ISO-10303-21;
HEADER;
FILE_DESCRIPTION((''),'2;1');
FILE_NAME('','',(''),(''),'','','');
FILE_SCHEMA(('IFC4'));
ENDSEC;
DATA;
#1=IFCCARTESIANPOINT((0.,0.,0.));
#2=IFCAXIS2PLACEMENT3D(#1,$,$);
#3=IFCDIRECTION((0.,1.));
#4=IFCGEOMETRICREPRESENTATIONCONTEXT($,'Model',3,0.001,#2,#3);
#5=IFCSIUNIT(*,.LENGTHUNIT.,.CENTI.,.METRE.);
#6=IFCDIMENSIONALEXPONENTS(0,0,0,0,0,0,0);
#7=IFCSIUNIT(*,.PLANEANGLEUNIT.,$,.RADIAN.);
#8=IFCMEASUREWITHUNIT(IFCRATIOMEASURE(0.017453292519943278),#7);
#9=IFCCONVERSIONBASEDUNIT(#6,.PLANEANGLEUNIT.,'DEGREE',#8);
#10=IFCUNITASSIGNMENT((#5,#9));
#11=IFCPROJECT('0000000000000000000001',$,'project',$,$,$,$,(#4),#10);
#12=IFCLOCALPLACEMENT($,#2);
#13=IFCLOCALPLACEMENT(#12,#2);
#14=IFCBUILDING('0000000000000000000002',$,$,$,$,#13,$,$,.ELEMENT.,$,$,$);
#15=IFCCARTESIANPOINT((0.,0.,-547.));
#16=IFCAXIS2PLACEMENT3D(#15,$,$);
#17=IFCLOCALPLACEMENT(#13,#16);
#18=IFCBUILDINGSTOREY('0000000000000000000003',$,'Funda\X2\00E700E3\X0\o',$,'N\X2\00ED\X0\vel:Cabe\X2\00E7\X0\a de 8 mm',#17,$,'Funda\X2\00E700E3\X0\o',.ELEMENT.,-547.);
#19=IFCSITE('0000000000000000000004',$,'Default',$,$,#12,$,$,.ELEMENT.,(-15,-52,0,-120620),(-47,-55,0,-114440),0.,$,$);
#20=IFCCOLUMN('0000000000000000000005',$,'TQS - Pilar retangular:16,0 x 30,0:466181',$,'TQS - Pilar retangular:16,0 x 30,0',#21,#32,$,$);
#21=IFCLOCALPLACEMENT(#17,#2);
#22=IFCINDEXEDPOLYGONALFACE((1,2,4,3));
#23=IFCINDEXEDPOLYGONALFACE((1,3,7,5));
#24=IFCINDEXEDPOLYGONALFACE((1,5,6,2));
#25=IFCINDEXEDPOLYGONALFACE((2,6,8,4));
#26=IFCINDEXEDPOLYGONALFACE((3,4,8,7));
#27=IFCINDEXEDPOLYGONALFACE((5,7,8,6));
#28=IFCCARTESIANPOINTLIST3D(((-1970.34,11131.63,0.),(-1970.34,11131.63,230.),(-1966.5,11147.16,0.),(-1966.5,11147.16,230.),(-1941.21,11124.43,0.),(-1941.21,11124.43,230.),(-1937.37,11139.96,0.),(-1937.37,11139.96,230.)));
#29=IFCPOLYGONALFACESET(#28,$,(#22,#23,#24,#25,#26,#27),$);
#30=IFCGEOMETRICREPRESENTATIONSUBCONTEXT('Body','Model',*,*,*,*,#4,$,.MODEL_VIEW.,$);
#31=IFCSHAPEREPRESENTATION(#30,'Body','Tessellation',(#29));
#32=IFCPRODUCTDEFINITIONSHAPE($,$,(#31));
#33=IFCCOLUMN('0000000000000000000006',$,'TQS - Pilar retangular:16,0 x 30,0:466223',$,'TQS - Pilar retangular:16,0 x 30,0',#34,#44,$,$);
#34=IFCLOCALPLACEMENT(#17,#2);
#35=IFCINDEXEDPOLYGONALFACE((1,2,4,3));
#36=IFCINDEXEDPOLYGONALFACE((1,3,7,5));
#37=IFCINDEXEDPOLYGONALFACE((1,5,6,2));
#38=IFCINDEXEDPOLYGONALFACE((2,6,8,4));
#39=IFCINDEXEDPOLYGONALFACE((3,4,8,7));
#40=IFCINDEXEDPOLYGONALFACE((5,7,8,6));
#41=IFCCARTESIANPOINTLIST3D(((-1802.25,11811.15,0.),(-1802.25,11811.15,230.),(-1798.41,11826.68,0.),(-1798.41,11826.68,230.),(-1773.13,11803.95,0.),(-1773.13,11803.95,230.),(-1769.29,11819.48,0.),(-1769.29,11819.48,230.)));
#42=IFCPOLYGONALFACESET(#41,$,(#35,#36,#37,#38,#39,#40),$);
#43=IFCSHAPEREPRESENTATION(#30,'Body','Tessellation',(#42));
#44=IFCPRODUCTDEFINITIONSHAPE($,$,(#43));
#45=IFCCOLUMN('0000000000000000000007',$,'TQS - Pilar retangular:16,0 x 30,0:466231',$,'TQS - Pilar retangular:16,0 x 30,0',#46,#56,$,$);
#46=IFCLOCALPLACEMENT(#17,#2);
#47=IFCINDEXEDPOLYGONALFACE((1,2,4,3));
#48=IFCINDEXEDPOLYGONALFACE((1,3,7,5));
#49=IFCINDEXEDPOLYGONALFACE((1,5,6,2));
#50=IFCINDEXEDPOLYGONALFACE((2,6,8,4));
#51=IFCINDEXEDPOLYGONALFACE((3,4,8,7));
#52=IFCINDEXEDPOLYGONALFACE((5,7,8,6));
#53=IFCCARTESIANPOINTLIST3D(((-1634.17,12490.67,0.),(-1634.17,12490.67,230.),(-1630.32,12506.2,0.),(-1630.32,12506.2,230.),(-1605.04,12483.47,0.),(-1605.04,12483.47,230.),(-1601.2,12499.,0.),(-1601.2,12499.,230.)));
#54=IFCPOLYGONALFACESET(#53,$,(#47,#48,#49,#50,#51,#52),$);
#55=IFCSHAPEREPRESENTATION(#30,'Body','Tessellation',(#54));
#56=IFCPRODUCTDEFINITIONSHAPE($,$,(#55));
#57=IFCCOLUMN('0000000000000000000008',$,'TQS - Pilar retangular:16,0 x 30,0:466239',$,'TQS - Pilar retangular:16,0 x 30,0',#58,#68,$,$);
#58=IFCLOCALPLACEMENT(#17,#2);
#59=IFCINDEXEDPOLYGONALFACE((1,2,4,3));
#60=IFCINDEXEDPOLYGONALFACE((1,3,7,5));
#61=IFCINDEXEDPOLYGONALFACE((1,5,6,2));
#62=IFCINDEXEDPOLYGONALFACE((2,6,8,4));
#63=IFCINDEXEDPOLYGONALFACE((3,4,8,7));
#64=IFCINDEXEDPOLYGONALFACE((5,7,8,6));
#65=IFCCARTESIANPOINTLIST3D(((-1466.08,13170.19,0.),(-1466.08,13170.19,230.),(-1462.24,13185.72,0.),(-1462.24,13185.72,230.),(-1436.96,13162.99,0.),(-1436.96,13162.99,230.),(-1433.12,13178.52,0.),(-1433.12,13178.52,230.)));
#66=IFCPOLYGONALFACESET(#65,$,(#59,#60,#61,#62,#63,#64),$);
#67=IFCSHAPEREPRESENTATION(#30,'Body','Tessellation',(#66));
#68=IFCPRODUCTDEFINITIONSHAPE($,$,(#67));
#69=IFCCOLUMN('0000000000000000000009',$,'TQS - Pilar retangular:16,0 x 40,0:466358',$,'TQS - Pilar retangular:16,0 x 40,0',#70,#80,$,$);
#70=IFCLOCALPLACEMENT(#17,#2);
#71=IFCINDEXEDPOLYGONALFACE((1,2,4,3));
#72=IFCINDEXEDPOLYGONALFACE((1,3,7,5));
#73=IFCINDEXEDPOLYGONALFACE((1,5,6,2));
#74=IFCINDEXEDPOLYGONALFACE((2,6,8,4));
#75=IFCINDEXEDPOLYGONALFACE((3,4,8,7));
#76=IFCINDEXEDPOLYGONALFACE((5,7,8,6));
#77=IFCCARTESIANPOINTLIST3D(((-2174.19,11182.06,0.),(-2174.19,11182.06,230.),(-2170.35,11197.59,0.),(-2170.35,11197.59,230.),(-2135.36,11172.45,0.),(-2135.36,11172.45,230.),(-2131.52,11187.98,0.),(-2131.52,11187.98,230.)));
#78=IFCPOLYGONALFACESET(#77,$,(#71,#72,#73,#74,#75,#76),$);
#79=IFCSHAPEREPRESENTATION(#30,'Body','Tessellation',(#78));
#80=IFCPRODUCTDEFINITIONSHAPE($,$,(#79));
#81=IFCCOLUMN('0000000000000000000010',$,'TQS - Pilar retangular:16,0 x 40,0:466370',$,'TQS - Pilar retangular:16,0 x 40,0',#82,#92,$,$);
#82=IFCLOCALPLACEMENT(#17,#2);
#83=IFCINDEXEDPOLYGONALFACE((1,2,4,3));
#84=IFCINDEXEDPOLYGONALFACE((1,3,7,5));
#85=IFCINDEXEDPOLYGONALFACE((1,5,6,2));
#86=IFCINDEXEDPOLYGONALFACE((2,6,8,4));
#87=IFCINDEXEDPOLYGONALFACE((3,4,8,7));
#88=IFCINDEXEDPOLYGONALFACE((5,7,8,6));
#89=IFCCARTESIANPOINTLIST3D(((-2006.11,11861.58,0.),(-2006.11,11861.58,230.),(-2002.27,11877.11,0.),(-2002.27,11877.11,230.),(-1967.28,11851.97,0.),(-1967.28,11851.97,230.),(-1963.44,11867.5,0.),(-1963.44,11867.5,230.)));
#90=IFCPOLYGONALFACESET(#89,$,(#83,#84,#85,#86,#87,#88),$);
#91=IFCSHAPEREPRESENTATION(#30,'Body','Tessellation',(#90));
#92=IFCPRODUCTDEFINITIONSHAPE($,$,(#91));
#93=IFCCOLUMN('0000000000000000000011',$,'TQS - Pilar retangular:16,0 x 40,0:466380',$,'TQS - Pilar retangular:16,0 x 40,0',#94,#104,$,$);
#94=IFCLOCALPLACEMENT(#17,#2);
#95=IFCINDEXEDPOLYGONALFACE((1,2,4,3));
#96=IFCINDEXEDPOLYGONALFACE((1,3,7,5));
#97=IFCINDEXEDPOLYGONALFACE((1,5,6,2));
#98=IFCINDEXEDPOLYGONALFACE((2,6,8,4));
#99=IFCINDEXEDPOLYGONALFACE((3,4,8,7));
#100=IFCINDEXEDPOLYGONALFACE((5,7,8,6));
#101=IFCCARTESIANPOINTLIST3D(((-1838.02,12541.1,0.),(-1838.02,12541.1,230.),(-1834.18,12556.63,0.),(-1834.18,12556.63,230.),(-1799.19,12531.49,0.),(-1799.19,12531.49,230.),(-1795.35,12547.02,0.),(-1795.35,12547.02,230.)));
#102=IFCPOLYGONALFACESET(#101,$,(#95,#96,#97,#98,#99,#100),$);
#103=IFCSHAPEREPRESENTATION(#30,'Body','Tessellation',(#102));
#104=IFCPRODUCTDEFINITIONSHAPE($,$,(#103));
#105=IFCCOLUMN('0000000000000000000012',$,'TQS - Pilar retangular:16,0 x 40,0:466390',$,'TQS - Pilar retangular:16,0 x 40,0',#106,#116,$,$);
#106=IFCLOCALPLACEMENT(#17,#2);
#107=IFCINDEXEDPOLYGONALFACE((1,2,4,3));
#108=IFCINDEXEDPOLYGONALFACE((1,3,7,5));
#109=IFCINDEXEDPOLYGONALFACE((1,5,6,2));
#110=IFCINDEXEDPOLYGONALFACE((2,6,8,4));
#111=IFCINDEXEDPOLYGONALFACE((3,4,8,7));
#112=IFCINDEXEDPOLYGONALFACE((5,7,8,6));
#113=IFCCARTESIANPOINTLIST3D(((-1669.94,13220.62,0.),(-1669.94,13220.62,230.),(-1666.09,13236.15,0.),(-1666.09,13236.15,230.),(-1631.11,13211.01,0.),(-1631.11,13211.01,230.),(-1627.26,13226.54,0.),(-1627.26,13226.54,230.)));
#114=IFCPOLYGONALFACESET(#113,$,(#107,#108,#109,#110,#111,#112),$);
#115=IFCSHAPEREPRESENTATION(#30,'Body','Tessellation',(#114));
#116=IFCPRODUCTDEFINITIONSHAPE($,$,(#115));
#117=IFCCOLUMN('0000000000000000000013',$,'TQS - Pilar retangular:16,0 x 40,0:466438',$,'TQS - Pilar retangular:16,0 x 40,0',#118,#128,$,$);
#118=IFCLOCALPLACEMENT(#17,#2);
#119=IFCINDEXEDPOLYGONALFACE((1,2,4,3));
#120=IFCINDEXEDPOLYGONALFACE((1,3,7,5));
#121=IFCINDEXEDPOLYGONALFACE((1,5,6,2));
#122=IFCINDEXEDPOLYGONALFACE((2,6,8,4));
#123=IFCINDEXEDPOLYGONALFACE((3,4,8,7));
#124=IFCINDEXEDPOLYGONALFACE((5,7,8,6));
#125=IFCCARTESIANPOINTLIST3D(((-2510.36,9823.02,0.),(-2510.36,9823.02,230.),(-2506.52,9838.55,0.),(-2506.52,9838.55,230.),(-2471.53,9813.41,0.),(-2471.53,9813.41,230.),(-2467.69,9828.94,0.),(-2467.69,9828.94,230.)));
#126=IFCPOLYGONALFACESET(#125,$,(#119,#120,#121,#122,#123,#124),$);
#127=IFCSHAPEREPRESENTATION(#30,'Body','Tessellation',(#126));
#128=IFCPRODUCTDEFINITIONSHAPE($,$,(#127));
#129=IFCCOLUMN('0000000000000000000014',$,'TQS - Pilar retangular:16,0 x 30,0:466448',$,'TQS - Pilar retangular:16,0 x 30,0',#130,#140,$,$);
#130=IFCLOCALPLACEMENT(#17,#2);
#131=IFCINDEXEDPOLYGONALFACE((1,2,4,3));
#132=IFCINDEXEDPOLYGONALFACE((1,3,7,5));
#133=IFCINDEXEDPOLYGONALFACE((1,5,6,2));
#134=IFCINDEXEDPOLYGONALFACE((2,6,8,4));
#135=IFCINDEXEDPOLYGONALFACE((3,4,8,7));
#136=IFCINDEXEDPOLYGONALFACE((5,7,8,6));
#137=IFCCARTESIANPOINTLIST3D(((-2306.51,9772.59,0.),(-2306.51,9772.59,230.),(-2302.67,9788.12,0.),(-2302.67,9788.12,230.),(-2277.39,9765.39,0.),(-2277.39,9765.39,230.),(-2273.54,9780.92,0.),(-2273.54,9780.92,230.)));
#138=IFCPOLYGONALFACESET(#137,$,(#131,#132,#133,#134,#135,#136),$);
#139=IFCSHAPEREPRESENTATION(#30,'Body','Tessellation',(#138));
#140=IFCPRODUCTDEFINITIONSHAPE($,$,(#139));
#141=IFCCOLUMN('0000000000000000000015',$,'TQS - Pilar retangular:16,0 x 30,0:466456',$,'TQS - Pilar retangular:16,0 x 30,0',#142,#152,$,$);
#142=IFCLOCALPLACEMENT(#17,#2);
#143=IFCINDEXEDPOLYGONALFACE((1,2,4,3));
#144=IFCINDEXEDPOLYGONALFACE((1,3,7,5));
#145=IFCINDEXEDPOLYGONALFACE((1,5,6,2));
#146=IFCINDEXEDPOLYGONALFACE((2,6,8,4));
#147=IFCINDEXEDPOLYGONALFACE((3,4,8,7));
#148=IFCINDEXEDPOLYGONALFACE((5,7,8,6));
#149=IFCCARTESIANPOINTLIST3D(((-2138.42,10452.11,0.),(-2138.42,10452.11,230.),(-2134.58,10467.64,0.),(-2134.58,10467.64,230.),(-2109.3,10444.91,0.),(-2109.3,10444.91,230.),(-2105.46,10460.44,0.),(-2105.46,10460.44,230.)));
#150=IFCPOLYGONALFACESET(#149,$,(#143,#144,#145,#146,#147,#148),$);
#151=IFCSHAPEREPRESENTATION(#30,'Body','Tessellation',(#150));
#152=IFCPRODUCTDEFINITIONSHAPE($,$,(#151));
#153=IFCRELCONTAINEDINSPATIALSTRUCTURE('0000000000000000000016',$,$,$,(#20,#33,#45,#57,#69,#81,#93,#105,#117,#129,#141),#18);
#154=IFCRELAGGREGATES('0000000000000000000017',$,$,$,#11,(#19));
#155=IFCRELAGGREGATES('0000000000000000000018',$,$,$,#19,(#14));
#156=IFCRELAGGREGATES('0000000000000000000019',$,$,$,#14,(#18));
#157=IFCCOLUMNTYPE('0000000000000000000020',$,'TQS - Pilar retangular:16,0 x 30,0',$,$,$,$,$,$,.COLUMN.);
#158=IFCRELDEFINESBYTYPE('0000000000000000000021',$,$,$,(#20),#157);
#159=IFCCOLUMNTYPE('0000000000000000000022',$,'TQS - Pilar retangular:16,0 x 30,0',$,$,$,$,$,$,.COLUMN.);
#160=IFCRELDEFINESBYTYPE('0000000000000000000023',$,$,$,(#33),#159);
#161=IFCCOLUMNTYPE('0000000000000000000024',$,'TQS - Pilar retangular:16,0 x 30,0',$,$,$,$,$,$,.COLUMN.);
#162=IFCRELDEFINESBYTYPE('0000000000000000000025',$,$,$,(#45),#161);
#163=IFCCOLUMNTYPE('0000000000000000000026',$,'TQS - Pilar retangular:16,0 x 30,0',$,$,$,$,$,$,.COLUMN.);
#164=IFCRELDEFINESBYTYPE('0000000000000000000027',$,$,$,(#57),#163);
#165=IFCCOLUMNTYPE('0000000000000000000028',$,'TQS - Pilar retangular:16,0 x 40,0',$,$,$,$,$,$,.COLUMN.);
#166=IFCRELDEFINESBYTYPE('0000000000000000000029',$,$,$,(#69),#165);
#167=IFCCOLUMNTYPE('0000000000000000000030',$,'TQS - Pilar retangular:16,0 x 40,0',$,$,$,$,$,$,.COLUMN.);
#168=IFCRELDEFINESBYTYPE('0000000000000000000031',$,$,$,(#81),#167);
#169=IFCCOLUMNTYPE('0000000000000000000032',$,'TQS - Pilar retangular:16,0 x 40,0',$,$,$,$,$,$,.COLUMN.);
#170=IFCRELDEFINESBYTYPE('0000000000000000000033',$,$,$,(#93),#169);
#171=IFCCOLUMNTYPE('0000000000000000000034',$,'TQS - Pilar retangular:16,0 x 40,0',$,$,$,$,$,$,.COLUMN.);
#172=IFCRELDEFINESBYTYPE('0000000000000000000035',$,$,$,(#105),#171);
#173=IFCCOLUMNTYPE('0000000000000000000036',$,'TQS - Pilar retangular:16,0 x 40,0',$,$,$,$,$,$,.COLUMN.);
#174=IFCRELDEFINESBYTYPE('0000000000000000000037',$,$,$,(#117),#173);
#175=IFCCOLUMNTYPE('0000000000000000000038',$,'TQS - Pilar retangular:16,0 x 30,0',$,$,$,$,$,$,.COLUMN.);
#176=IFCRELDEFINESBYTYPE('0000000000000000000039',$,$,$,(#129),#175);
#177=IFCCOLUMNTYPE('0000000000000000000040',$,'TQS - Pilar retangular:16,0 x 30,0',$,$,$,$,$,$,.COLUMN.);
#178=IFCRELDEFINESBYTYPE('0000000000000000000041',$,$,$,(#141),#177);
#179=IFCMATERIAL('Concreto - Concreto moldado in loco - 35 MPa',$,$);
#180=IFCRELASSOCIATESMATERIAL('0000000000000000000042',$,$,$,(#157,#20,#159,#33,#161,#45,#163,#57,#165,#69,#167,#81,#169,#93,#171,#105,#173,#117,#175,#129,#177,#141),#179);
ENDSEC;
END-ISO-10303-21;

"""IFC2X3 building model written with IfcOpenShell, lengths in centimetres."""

from ifc_helpers import new_model, entity, si_unit, converted_unit, direction, frame, frame_2d, origin, origin_2d_with_axis, place, context, subcontext, project, spatial, rectangle, extrude, source, transform, mapped, material, type_object, type_shapes, element, save


model = new_model("IFC2X3")

# Units and contexts
model_context = context("Model", 3, precision=0.001, world=origin(), true_north=direction((0.0, 1.0)))
body_context = subcontext(model_context, "Body", "Model", "MODEL_VIEW")
ifc_project = project(units=[si_unit("LENGTHUNIT", "METRE", prefix="CENTI"), converted_unit("PLANEANGLEUNIT", "DEGREE", entity("IfcRatioMeasure", 0.017453292519943278), si_unit("PLANEANGLEUNIT", "RADIAN"), dimensions=[0, 0, 0, 0, 0, 0, 0])], contexts=[model_context])

# Site, building, storey
site_placement = place(None, origin())
site = spatial("IfcSite", under=ifc_project, at=site_placement, Name="Default", CompositionType="ELEMENT", RefLatitude=(-15, -52, 0, -120620), RefLongitude=(-47, -55, 0, -114440), RefElevation=0.0)
building_placement = place(site_placement, origin())
building = spatial("IfcBuilding", under=site, at=building_placement, CompositionType="ELEMENT")
storey_placement = place(building_placement, frame((0.0, 0.0, -547.0)))
storey = spatial("IfcBuildingStorey", under=building, at=storey_placement, Name="Fundação", ObjectType="Nível:Cabeça de 8 mm", LongName="Fundação", CompositionType="ELEMENT", Elevation=-547.0)

# Columns
ifc_material_1 = material(Name="Concreto - Concreto moldado in loco - 35 MPa")
column_type_1 = type_object("IfcColumnType", Name="TQS - Pilar retangular:16,0 x 30,0", PredefinedType="COLUMN", material=ifc_material_1)
shared_shape_1 = source(origin(), body_context, "Body", "SweptSolid", [
    extrude(rectangle(XDim=30.0, YDim=16.0, at=frame_2d((0.0, 0.0), x_axis=(1.0, 0.0))), frame((-1953.86, 11135.79, -547.0), z_axis=(0.0, 0.0, 1.0), x_axis=(-0.970743, 0.240122, 0.0)), (0.0, 0.0, 1.0), 230.0),
])
type_shapes(column_type_1, [shared_shape_1])
column_1_placement = place(storey_placement, frame((0.0, 0.0, 547.0)))
element("IfcColumn", 1, at=column_1_placement, inside=storey, type_object=column_type_1, material=ifc_material_1, Name="TQS - Pilar retangular:16,0 x 30,0:466181", ObjectType="TQS - Pilar retangular:16,0 x 30,0", context=body_context, shape_type="MappedRepresentation", body=[
    mapped(shared_shape_1, transform((0.0, 0.0, 0.0), scale=1.0)),
])
column_type_2 = type_object("IfcColumnType", Name="TQS - Pilar retangular:16,0 x 30,0", PredefinedType="COLUMN", material=ifc_material_1)
shared_shape_2 = source(origin(), body_context, "Body", "SweptSolid", [
    extrude(rectangle(XDim=30.0, YDim=16.0, at=origin_2d_with_axis()), frame((-1785.77, 11815.31, -547.0), z_axis=(0.0, 0.0, 1.0), x_axis=(-0.970743, 0.240122, 0.0)), (0.0, 0.0, 1.0), 230.0),
])
type_shapes(column_type_2, [shared_shape_2])
column_2_placement = place(storey_placement, frame((0.0, 0.0, 547.0)))
element("IfcColumn", 2, at=column_2_placement, inside=storey, type_object=column_type_2, material=ifc_material_1, Name="TQS - Pilar retangular:16,0 x 30,0:466223", ObjectType="TQS - Pilar retangular:16,0 x 30,0", context=body_context, shape_type="MappedRepresentation", body=[
    mapped(shared_shape_2, transform((0.0, 0.0, 0.0), scale=1.0)),
])
column_type_3 = type_object("IfcColumnType", Name="TQS - Pilar retangular:16,0 x 30,0", PredefinedType="COLUMN", material=ifc_material_1)
shared_shape_3 = source(origin(), body_context, "Body", "SweptSolid", [
    extrude(rectangle(XDim=30.0, YDim=16.0, at=origin_2d_with_axis()), frame((0.0, 0.0, -547.0), z_axis=(0.0, 0.0, 1.0), x_axis=(0.0, -1.0, 0.0)), (0.0, 0.0, 1.0), 230.0),
])
type_shapes(column_type_3, [shared_shape_3])
column_3_placement = place(storey_placement, frame((-1617.68, 12494.83, 547.0), z_axis=(0.0, 0.0, 1.0), x_axis=(0.240122, 0.970743, 0.0)))
element("IfcColumn", 3, at=column_3_placement, inside=storey, type_object=column_type_3, material=ifc_material_1, Name="TQS - Pilar retangular:16,0 x 30,0:466231", ObjectType="TQS - Pilar retangular:16,0 x 30,0", context=body_context, shape_type="MappedRepresentation", body=[
    mapped(shared_shape_3, transform((0.0, 0.0, 0.0), scale=1.0)),
])
column_type_4 = type_object("IfcColumnType", Name="TQS - Pilar retangular:16,0 x 30,0", PredefinedType="COLUMN", material=ifc_material_1)
shared_shape_4 = source(origin(), body_context, "Body", "SweptSolid", [
    extrude(rectangle(XDim=30.0, YDim=16.0, at=origin_2d_with_axis()), frame((-1449.6, 13174.35, -547.0), z_axis=(0.0, 0.0, 1.0), x_axis=(-0.970743, 0.240122, 0.0)), (0.0, 0.0, 1.0), 230.0),
])
type_shapes(column_type_4, [shared_shape_4])
column_4_placement = place(storey_placement, frame((0.0, 0.0, 547.0)))
element("IfcColumn", 4, at=column_4_placement, inside=storey, type_object=column_type_4, material=ifc_material_1, Name="TQS - Pilar retangular:16,0 x 30,0:466239", ObjectType="TQS - Pilar retangular:16,0 x 30,0", context=body_context, shape_type="MappedRepresentation", body=[
    mapped(shared_shape_4, transform((0.0, 0.0, 0.0), scale=1.0)),
])
column_type_5 = type_object("IfcColumnType", Name="TQS - Pilar retangular:16,0 x 40,0", PredefinedType="COLUMN", material=ifc_material_1)
shared_shape_5 = source(origin(), body_context, "Body", "SweptSolid", [
    extrude(rectangle(XDim=40.0, YDim=16.0, at=origin_2d_with_axis()), frame((-2152.86, 11185.02, -547.0), z_axis=(0.0, 0.0, 1.0), x_axis=(-0.970743, 0.240122, 0.0)), (0.0, 0.0, 1.0), 230.0),
])
type_shapes(column_type_5, [shared_shape_5])
column_5_placement = place(storey_placement, frame((0.0, 0.0, 547.0)))
element("IfcColumn", 5, at=column_5_placement, inside=storey, type_object=column_type_5, material=ifc_material_1, Name="TQS - Pilar retangular:16,0 x 40,0:466358", ObjectType="TQS - Pilar retangular:16,0 x 40,0", context=body_context, shape_type="MappedRepresentation", body=[
    mapped(shared_shape_5, transform((0.0, 0.0, 0.0), scale=1.0)),
])
column_type_6 = type_object("IfcColumnType", Name="TQS - Pilar retangular:16,0 x 40,0", PredefinedType="COLUMN", material=ifc_material_1)
shared_shape_6 = source(origin(), body_context, "Body", "SweptSolid", [
    extrude(rectangle(XDim=40.0, YDim=16.0, at=origin_2d_with_axis()), frame((-1984.77, 11864.54, -547.0), z_axis=(0.0, 0.0, 1.0), x_axis=(-0.970743, 0.240122, 0.0)), (0.0, 0.0, 1.0), 230.0),
])
type_shapes(column_type_6, [shared_shape_6])
column_6_placement = place(storey_placement, frame((0.0, 0.0, 547.0)))
element("IfcColumn", 6, at=column_6_placement, inside=storey, type_object=column_type_6, material=ifc_material_1, Name="TQS - Pilar retangular:16,0 x 40,0:466370", ObjectType="TQS - Pilar retangular:16,0 x 40,0", context=body_context, shape_type="MappedRepresentation", body=[
    mapped(shared_shape_6, transform((0.0, 0.0, 0.0), scale=1.0)),
])
column_type_7 = type_object("IfcColumnType", Name="TQS - Pilar retangular:16,0 x 40,0", PredefinedType="COLUMN", material=ifc_material_1)
shared_shape_7 = source(origin(), body_context, "Body", "SweptSolid", [
    extrude(rectangle(XDim=40.0, YDim=16.0, at=origin_2d_with_axis()), frame((-1816.69, 12544.06, -547.0), z_axis=(0.0, 0.0, 1.0), x_axis=(-0.970743, 0.240122, 0.0)), (0.0, 0.0, 1.0), 230.0),
])
type_shapes(column_type_7, [shared_shape_7])
column_7_placement = place(storey_placement, frame((0.0, 0.0, 547.0)))
element("IfcColumn", 7, at=column_7_placement, inside=storey, type_object=column_type_7, material=ifc_material_1, Name="TQS - Pilar retangular:16,0 x 40,0:466380", ObjectType="TQS - Pilar retangular:16,0 x 40,0", context=body_context, shape_type="MappedRepresentation", body=[
    mapped(shared_shape_7, transform((0.0, 0.0, 0.0), scale=1.0)),
])
column_type_8 = type_object("IfcColumnType", Name="TQS - Pilar retangular:16,0 x 40,0", PredefinedType="COLUMN", material=ifc_material_1)
shared_shape_8 = source(origin(), body_context, "Body", "SweptSolid", [
    extrude(rectangle(XDim=40.0, YDim=16.0, at=origin_2d_with_axis()), frame((-1648.6, 13223.58, -547.0), z_axis=(0.0, 0.0, 1.0), x_axis=(-0.970743, 0.240122, 0.0)), (0.0, 0.0, 1.0), 230.0),
])
type_shapes(column_type_8, [shared_shape_8])
column_8_placement = place(storey_placement, frame((0.0, 0.0, 547.0)))
element("IfcColumn", 8, at=column_8_placement, inside=storey, type_object=column_type_8, material=ifc_material_1, Name="TQS - Pilar retangular:16,0 x 40,0:466390", ObjectType="TQS - Pilar retangular:16,0 x 40,0", context=body_context, shape_type="MappedRepresentation", body=[
    mapped(shared_shape_8, transform((0.0, 0.0, 0.0), scale=1.0)),
])
column_type_9 = type_object("IfcColumnType", Name="TQS - Pilar retangular:16,0 x 40,0", PredefinedType="COLUMN", material=ifc_material_1)
shared_shape_9 = source(origin(), body_context, "Body", "SweptSolid", [
    extrude(rectangle(XDim=40.0, YDim=16.0, at=origin_2d_with_axis()), frame((-2489.03, 9825.98, -547.0), z_axis=(0.0, 0.0, 1.0), x_axis=(-0.970743, 0.240122, 0.0)), (0.0, 0.0, 1.0), 230.0),
])
type_shapes(column_type_9, [shared_shape_9])
column_9_placement = place(storey_placement, frame((0.0, 0.0, 547.0)))
element("IfcColumn", 9, at=column_9_placement, inside=storey, type_object=column_type_9, material=ifc_material_1, Name="TQS - Pilar retangular:16,0 x 40,0:466438", ObjectType="TQS - Pilar retangular:16,0 x 40,0", context=body_context, shape_type="MappedRepresentation", body=[
    mapped(shared_shape_9, transform((0.0, 0.0, 0.0), scale=1.0)),
])
column_type_10 = type_object("IfcColumnType", Name="TQS - Pilar retangular:16,0 x 30,0", PredefinedType="COLUMN", material=ifc_material_1)
shared_shape_10 = source(origin(), body_context, "Body", "SweptSolid", [
    extrude(rectangle(XDim=30.0, YDim=16.0, at=origin_2d_with_axis()), frame((-2290.03, 9776.75, -547.0), z_axis=(0.0, 0.0, 1.0), x_axis=(-0.970743, 0.240122, 0.0)), (0.0, 0.0, 1.0), 230.0),
])
type_shapes(column_type_10, [shared_shape_10])
column_10_placement = place(storey_placement, frame((0.0, 0.0, 547.0)))
element("IfcColumn", 10, at=column_10_placement, inside=storey, type_object=column_type_10, material=ifc_material_1, Name="TQS - Pilar retangular:16,0 x 30,0:466448", ObjectType="TQS - Pilar retangular:16,0 x 30,0", context=body_context, shape_type="MappedRepresentation", body=[
    mapped(shared_shape_10, transform((0.0, 0.0, 0.0), scale=1.0)),
])
column_type_11 = type_object("IfcColumnType", Name="TQS - Pilar retangular:16,0 x 30,0", PredefinedType="COLUMN", material=ifc_material_1)
shared_shape_11 = source(origin(), body_context, "Body", "SweptSolid", [
    extrude(rectangle(XDim=30.0, YDim=16.0, at=origin_2d_with_axis()), frame((-2121.94, 10456.27, -547.0), z_axis=(0.0, 0.0, 1.0), x_axis=(-0.970743, 0.240122, 0.0)), (0.0, 0.0, 1.0), 230.0),
])
type_shapes(column_type_11, [shared_shape_11])
column_11_placement = place(storey_placement, frame((0.0, 0.0, 547.0)))
element("IfcColumn", 11, at=column_11_placement, inside=storey, type_object=column_type_11, material=ifc_material_1, Name="TQS - Pilar retangular:16,0 x 30,0:466456", ObjectType="TQS - Pilar retangular:16,0 x 30,0", context=body_context, shape_type="MappedRepresentation", body=[
    mapped(shared_shape_11, transform((0.0, 0.0, 0.0), scale=1.0)),
])

save(model, "model.ifc")
